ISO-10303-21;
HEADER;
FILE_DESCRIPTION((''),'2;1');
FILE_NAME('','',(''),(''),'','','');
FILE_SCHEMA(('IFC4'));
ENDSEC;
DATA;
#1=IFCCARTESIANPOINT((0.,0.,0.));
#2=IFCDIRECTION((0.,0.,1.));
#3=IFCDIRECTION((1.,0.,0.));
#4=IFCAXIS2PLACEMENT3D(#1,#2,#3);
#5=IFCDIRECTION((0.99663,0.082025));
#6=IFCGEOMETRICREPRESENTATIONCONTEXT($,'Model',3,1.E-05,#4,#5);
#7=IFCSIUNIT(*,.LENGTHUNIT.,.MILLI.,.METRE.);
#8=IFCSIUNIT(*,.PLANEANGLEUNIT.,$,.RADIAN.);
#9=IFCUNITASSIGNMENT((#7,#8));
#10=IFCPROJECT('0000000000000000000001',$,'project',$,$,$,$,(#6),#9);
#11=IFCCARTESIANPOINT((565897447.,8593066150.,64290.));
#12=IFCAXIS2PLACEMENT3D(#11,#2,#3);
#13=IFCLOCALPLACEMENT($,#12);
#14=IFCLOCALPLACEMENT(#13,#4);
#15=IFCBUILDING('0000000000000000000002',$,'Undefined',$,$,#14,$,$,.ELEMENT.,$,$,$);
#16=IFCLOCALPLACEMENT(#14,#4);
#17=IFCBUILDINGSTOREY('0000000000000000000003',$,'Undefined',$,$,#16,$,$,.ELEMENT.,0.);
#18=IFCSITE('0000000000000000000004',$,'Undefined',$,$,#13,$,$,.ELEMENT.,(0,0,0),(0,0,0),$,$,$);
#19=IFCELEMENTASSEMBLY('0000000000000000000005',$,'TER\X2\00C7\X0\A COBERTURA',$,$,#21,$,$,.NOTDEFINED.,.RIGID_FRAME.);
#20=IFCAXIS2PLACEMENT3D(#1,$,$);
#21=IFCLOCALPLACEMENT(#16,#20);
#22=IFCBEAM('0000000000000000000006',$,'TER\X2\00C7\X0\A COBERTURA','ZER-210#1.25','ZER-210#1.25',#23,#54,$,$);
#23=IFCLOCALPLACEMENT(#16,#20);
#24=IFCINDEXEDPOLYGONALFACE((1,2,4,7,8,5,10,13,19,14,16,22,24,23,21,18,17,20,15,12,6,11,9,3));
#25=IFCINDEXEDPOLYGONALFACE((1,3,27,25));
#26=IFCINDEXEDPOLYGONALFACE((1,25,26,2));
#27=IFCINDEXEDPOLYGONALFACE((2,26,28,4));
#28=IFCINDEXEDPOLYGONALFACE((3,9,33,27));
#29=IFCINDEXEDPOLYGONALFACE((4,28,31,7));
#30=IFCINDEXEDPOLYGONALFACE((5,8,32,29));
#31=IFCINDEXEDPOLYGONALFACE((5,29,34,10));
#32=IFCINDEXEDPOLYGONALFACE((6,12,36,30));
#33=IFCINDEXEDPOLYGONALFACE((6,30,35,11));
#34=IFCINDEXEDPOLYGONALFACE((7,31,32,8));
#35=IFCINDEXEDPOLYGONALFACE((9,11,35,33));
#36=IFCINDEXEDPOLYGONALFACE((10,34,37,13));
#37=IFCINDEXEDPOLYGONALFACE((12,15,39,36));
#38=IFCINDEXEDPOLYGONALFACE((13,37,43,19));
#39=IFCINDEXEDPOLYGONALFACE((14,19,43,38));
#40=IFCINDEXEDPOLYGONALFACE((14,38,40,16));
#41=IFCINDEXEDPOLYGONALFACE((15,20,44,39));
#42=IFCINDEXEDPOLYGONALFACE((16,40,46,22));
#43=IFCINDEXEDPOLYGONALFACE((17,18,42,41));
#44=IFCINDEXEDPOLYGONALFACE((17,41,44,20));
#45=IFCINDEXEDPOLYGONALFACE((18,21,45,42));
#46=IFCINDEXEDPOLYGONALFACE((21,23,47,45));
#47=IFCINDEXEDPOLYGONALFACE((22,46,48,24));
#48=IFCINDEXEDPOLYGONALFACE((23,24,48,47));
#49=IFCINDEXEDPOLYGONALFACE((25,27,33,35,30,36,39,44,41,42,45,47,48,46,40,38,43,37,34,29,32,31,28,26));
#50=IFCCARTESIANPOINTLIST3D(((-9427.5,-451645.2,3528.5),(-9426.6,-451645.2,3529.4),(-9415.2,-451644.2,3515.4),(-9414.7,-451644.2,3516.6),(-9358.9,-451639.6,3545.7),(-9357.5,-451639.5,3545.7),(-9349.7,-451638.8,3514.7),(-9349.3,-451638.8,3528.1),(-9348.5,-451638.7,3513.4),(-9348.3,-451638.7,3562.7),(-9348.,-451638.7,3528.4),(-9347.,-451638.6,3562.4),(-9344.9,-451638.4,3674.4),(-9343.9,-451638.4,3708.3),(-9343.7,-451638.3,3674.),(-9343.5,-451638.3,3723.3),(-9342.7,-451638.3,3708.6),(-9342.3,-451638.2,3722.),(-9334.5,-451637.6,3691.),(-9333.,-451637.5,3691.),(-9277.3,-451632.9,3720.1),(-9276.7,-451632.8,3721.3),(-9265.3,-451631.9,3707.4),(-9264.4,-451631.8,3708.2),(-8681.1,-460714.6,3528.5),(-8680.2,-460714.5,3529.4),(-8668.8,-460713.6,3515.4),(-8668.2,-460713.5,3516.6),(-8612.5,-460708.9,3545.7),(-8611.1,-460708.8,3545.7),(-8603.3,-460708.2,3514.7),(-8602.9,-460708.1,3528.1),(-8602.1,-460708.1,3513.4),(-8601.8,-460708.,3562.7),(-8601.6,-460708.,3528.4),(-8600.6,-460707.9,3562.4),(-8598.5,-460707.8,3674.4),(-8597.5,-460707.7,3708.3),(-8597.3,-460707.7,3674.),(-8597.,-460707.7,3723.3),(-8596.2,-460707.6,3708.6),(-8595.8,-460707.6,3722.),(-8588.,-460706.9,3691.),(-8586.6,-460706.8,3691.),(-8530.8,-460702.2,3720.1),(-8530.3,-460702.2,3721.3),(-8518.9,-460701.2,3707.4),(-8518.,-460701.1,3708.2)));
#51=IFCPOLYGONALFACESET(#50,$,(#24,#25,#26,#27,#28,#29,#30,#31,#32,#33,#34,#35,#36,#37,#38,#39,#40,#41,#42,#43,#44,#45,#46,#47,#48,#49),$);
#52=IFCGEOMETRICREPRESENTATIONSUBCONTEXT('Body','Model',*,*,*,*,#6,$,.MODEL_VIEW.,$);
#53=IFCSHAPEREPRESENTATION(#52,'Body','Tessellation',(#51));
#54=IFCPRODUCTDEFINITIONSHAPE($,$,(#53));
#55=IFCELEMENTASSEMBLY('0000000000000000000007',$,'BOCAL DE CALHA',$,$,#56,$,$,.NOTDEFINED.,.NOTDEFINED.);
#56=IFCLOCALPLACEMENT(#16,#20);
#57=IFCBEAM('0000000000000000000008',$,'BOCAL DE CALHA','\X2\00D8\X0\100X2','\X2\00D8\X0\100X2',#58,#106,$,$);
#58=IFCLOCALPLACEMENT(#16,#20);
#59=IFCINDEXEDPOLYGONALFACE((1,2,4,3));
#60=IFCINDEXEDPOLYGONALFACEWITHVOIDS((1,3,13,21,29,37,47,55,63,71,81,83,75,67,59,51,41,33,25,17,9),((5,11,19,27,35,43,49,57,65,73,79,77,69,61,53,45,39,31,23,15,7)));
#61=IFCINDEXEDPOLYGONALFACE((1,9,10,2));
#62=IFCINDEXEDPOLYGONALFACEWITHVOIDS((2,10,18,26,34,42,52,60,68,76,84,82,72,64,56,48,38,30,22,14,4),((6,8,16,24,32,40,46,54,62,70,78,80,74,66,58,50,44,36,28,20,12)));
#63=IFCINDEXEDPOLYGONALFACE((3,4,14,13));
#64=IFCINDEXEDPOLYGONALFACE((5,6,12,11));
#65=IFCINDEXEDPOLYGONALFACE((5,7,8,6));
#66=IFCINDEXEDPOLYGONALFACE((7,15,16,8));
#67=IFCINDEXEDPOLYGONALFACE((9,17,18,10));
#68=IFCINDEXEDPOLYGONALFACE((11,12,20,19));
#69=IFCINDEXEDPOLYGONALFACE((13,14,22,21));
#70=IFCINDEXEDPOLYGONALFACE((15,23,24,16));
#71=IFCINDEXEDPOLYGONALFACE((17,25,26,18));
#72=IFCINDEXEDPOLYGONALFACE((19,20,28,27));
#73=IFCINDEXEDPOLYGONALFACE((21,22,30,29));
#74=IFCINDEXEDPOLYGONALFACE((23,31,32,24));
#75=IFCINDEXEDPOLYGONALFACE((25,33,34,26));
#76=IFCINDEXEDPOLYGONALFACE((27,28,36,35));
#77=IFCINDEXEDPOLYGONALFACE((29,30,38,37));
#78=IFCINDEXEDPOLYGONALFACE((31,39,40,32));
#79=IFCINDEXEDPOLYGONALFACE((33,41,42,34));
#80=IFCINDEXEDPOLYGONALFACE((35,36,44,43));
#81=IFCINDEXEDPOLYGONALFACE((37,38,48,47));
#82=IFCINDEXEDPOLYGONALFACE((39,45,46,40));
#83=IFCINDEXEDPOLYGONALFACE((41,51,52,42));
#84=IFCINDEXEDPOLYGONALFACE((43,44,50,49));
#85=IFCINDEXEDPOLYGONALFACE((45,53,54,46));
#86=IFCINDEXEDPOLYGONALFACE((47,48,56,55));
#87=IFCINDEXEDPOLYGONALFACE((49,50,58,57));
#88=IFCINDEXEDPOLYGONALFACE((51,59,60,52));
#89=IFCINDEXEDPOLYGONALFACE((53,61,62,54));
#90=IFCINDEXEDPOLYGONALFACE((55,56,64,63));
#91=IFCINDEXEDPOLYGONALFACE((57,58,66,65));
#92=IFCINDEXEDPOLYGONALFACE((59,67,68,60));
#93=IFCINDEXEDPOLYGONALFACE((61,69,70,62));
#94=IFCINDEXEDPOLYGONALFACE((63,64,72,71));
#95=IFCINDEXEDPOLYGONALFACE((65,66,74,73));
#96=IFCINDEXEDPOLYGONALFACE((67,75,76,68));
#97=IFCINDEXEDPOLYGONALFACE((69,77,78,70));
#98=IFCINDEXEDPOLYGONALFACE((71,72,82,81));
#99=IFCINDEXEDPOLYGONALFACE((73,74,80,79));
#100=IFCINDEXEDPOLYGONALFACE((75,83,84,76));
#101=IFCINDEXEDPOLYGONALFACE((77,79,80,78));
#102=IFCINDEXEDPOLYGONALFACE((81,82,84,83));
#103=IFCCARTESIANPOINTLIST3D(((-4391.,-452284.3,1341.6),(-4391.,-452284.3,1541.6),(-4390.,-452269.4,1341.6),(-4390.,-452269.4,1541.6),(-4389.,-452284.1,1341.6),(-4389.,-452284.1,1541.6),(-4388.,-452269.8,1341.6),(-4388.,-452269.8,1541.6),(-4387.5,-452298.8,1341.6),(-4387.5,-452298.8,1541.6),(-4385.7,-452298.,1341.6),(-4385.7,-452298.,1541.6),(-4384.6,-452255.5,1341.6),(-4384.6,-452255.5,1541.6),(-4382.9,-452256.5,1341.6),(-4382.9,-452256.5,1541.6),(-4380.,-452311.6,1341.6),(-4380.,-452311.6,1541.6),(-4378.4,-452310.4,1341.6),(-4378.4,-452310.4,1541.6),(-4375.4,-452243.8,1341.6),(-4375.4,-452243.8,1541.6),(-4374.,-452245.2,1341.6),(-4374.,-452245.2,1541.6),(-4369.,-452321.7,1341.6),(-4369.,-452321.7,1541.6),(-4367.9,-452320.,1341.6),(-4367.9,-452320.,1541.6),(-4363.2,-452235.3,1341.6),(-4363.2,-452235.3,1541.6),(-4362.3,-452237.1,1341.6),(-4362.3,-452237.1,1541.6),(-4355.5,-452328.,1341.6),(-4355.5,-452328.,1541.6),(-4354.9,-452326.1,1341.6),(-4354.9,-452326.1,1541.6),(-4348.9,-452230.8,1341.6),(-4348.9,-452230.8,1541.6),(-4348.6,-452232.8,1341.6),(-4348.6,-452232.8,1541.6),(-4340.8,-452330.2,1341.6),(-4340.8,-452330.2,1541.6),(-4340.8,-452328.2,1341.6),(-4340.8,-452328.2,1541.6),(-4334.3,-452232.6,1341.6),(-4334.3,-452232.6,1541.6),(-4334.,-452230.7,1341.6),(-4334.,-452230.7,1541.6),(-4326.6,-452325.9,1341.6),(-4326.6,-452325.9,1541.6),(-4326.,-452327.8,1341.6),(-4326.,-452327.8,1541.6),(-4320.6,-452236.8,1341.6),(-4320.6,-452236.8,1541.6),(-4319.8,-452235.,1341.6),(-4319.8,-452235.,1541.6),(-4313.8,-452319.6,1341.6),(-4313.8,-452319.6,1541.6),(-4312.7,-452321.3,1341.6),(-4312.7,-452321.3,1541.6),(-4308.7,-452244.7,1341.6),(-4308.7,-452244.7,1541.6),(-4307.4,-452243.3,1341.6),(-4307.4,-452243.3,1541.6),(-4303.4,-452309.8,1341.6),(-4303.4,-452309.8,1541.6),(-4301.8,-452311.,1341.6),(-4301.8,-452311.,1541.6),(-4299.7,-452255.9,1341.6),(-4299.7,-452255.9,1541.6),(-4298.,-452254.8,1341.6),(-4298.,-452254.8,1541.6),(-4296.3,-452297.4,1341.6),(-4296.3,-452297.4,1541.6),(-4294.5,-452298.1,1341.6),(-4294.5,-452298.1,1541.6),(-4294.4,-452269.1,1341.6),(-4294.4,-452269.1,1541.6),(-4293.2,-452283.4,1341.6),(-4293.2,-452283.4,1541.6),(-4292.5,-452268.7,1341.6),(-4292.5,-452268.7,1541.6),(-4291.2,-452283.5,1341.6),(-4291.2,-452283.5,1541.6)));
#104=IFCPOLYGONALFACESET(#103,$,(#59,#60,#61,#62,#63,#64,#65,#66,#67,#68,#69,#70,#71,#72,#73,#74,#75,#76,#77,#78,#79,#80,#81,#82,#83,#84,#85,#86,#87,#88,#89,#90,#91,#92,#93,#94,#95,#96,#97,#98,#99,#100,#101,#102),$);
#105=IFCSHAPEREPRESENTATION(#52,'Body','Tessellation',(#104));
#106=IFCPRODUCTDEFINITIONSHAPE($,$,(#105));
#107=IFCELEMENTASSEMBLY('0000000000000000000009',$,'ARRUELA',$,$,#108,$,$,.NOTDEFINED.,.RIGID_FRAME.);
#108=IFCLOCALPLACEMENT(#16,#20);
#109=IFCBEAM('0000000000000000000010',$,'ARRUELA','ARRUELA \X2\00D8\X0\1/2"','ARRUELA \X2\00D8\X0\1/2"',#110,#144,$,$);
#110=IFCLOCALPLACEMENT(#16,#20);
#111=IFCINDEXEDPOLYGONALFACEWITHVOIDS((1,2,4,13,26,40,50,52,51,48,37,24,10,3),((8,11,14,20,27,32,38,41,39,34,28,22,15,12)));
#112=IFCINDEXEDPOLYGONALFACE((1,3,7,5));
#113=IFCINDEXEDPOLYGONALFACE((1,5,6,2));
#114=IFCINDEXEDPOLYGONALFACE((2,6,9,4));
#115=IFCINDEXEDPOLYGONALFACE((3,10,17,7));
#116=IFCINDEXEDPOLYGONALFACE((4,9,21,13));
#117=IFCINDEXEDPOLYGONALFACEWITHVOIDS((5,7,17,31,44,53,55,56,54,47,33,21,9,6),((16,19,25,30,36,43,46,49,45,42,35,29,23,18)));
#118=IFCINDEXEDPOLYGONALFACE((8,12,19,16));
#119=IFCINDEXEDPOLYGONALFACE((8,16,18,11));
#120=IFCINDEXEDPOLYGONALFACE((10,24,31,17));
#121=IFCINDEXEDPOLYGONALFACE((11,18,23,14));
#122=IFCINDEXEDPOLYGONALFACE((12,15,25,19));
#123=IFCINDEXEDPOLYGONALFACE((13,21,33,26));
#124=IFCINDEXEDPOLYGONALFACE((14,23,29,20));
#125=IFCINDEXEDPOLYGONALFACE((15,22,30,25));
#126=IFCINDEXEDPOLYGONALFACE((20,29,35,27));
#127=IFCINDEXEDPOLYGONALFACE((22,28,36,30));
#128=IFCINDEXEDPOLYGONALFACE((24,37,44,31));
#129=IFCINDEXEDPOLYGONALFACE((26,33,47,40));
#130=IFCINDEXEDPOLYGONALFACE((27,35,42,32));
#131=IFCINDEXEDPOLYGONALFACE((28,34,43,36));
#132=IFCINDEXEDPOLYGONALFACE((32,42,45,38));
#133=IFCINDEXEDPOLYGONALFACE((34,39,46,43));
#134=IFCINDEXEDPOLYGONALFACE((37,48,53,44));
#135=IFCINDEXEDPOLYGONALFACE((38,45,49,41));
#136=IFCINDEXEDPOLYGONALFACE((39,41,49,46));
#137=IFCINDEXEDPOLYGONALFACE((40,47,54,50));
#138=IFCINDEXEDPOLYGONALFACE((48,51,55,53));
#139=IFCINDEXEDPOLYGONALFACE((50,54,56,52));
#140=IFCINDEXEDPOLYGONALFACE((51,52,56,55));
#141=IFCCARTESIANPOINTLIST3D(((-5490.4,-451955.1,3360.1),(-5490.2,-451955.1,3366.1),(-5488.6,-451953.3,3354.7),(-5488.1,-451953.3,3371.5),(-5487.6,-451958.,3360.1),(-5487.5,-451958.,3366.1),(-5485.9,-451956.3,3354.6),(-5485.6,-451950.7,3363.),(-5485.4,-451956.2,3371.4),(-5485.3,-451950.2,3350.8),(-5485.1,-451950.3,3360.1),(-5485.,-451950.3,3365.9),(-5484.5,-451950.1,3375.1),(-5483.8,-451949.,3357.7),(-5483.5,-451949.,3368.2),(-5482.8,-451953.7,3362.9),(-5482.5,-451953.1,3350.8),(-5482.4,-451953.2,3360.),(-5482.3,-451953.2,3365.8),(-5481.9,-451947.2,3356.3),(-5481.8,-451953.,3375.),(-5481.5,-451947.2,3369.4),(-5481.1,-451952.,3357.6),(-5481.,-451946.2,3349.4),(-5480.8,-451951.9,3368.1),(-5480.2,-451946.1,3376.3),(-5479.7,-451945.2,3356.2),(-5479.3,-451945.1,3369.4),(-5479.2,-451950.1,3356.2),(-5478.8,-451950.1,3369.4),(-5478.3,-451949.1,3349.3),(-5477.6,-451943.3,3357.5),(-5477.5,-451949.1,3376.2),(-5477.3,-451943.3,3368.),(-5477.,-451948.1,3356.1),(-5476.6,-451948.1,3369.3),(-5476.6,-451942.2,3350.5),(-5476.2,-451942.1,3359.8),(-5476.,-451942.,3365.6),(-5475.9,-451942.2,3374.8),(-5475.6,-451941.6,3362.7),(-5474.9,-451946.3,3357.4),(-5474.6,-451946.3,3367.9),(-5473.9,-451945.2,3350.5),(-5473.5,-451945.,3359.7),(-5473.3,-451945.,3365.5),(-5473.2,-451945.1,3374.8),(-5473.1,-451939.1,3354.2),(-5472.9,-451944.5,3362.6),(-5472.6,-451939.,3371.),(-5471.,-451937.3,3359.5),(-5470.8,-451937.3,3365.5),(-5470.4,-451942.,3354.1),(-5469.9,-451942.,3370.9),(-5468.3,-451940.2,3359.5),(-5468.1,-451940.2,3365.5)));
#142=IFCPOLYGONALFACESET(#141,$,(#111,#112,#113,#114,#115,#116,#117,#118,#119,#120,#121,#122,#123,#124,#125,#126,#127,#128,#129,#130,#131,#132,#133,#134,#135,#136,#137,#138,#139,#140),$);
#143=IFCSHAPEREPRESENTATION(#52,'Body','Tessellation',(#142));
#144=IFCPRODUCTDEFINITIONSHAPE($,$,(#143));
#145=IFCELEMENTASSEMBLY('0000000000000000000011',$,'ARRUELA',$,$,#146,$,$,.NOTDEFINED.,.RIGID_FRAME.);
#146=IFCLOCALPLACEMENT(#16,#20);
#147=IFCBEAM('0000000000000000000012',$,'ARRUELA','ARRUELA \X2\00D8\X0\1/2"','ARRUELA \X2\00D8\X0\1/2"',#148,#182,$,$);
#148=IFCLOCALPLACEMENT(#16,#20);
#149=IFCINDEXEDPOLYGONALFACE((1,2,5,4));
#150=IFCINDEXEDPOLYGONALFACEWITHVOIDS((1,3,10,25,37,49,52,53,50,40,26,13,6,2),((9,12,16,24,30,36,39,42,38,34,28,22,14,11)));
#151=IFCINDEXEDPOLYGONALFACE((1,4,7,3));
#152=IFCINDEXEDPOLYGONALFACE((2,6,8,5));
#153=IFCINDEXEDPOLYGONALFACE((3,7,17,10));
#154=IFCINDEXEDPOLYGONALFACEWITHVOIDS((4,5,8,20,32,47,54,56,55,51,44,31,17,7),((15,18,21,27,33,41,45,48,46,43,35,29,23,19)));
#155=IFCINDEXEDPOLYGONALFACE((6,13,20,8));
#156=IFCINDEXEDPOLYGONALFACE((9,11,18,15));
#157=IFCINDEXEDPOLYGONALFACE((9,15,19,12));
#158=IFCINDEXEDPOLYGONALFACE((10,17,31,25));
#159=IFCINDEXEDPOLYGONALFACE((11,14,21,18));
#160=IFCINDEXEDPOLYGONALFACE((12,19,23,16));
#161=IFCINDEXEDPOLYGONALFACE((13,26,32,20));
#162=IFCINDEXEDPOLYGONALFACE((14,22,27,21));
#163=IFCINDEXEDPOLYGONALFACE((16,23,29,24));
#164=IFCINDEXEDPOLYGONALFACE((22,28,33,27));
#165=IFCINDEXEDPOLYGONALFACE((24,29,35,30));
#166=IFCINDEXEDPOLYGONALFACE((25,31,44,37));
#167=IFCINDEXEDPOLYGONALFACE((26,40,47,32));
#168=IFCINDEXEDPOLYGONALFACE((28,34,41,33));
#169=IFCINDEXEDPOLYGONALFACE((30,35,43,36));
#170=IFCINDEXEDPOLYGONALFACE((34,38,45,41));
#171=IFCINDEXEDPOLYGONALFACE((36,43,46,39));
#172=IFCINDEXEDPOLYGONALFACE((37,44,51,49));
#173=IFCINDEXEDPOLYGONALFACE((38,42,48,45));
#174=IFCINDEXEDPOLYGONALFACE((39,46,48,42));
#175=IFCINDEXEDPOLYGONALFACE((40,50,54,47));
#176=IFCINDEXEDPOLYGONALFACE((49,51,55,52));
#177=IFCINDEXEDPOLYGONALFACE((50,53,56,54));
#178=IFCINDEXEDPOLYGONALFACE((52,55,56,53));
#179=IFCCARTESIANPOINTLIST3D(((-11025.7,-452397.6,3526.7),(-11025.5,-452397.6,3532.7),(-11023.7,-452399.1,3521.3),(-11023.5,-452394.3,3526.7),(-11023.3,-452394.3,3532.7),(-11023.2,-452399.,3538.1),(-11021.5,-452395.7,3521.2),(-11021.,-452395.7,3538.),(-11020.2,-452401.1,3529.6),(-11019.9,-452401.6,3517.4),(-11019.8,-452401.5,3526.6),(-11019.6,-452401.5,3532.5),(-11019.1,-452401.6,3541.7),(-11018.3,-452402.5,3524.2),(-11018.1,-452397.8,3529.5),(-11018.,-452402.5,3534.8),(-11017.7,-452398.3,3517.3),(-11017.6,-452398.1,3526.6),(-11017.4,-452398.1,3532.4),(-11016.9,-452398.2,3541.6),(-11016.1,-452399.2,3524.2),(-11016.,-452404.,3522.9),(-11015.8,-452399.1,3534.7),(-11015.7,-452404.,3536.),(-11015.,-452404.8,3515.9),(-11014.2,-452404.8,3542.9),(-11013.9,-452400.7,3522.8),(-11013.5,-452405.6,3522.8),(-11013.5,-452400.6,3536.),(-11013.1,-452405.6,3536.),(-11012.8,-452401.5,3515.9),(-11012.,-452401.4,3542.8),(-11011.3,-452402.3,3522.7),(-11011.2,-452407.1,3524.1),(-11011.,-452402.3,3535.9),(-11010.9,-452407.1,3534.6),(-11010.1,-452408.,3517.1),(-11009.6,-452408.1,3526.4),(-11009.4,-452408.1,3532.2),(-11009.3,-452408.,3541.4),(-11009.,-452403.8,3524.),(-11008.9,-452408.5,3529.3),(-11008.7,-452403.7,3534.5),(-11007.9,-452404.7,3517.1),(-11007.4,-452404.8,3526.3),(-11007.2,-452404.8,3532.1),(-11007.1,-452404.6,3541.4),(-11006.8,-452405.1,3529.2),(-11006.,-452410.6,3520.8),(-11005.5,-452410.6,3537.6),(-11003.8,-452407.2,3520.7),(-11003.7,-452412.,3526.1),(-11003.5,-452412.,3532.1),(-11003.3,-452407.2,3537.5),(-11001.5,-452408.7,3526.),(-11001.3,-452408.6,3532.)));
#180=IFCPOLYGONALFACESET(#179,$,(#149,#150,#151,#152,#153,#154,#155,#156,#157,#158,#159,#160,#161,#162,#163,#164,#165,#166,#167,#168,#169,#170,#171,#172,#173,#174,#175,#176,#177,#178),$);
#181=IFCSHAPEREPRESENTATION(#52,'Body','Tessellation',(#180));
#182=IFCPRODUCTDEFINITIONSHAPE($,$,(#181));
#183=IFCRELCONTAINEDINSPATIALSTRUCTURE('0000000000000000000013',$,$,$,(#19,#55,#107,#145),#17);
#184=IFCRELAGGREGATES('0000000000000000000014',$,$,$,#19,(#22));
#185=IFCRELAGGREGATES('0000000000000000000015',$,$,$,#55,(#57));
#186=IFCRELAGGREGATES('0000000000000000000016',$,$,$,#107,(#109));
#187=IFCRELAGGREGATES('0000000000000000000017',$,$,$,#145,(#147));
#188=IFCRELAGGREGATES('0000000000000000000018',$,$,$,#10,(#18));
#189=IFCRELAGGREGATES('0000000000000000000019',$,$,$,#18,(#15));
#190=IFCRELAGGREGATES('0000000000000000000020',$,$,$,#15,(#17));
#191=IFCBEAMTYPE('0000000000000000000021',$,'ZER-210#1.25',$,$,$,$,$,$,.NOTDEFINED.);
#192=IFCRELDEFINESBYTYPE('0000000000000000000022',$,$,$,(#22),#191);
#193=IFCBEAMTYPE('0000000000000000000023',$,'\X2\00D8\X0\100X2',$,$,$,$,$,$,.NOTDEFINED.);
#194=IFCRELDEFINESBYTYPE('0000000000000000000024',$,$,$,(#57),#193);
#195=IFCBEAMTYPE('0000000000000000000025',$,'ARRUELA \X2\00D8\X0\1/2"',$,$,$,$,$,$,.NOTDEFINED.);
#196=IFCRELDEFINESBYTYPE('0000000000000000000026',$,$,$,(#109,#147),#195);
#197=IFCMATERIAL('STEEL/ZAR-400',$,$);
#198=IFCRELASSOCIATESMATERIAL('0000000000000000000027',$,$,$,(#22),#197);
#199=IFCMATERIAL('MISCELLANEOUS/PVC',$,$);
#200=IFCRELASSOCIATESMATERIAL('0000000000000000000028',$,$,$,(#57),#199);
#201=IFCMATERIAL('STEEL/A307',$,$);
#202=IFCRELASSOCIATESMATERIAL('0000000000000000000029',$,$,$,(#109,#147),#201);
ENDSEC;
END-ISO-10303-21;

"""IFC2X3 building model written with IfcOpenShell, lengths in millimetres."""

from ifc_helpers import new_model, si_unit, direction, frame, origin_with_axes, origin_2d_with_axis, place, context, subcontext, project, spatial, polyline, hollow_circle, outline, extrude, material, type_object, element, aggregate, save


model = new_model("IFC2X3")

# Units and contexts
model_context = context("Model", 3, precision=1e-05, world=origin_with_axes(), true_north=direction((0.99663, 0.082025)))
body_context = subcontext(model_context, "Body", "Model", "MODEL_VIEW")
ifc_project = project(units=[si_unit("LENGTHUNIT", "METRE", prefix="MILLI"), si_unit("PLANEANGLEUNIT", "RADIAN")], contexts=[model_context])

# Site, building, storey
site_placement = place(None, frame((565897447.0, 8593066150.0, 64290.0), z_axis=(0.0, 0.0, 1.0), x_axis=(1.0, 0.0, 0.0)))
site = spatial("IfcSite", under=ifc_project, at=site_placement, Name="Undefined", CompositionType="ELEMENT", RefLatitude=(0, 0, 0), RefLongitude=(0, 0, 0))
building_placement = place(site_placement, origin_with_axes())
building = spatial("IfcBuilding", under=site, at=building_placement, Name="Undefined", CompositionType="ELEMENT")
storey_placement = place(building_placement, origin_with_axes())
storey = spatial("IfcBuildingStorey", under=building, at=storey_placement, Name="Undefined", CompositionType="ELEMENT", Elevation=0.0)

# Element assemblies, beams
ifc_material_1 = material(Name="STEEL/ZAR-400")
beam_type_1 = type_object("IfcBeamType", Name="ZER-210#1.25", PredefinedType="NOTDEFINED")
assembly_1_placement = place(storey_placement, origin_with_axes())
assembly_1 = element("IfcElementAssembly", 1, at=assembly_1_placement, inside=storey, Name="TERÇA COBERTURA", AssemblyPlace="NOTDEFINED", PredefinedType="RIGID_FRAME")
beam_1_placement = place(assembly_1_placement, frame((-9346.0, -451638.5, 3618.4), z_axis=(0.029885, 0.00246, 0.99955), x_axis=(0.082025, -0.99663, 0.0)))
beam_1 = element("IfcBeam", 2, at=beam_1_placement, type_object=beam_type_1, material=ifc_material_1, Name="TERÇA COBERTURA", Description="ZER-210#1.25", ObjectType="ZER-210#1.25", context=body_context, shape_type="SweptSolid", body=[
    extrude(outline(polyline([(-65.9, 103.7), (-78.2, 91.4), (-79.1, 92.3), (-66.4, 105.0), (0.6, 105.0), (0.6, 90.0), (-9.4, 73.0), (0.6, 56.0), (0.6, -55.7), (10.8, -73.0), (0.6, -90.3), (0.6, -103.8), (65.9, -103.7), (78.2, -91.4), (79.1, -92.3), (66.4, -105.0), (-0.6, -105.0), (-0.6, -90.0), (9.4, -73.0), (-0.6, -56.0), (-0.6, 55.7), (-10.8, 73.0), (-0.6, 90.3), (-0.6, 103.8), (-65.9, 103.7)])), frame((9100.0, 0.0, 0.0), z_axis=(-1.0, 0.0, 0.0), x_axis=(0.0, -1.0, 0.0)), (0.0, 0.0, 1.0), 9100.0),
])
aggregate(assembly_1, [beam_1])
assembly_2_placement = place(storey_placement, origin_with_axes())
assembly_2 = element("IfcElementAssembly", 3, at=assembly_2_placement, inside=storey, Name="BOCAL DE CALHA", AssemblyPlace="NOTDEFINED", PredefinedType="NOTDEFINED")
ifc_material_2 = material(Name="MISCELLANEOUS/PVC")
beam_type_2 = type_object("IfcBeamType", Name="Ø100X2", PredefinedType="NOTDEFINED")
beam_2_placement = place(assembly_2_placement, frame((-4341.1, -452280.2, 1541.6), z_axis=(0.082025, -0.99663, 0.0), x_axis=(0.0, 0.0, -1.0)))
beam_2 = element("IfcBeam", 4, at=beam_2_placement, type_object=beam_type_2, material=ifc_material_2, Name="BOCAL DE CALHA", Description="Ø100X2", ObjectType="Ø100X2", context=body_context, shape_type="SweptSolid", body=[
    extrude(hollow_circle(Radius=50.0, WallThickness=2.0, at=origin_2d_with_axis()), frame((200.0, 0.0, 0.0), z_axis=(-1.0, 0.0, 0.0), x_axis=(0.0, -1.0, 0.0)), (0.0, 0.0, 1.0), 200.0),
])
aggregate(assembly_2, [beam_2])
assembly_3_placement = place(storey_placement, origin_with_axes())
assembly_3 = element("IfcElementAssembly", 5, at=assembly_3_placement, inside=storey, Name="ARRUELA", AssemblyPlace="NOTDEFINED", PredefinedType="RIGID_FRAME")
ifc_material_3 = material(Name="STEEL/A307")
beam_type_3 = type_object("IfcBeamType", Name="ARRUELA Ø1/2\"", PredefinedType="NOTDEFINED")
beam_3_placement = place(assembly_3_placement, frame((-5477.9, -451949.1, 3362.8), z_axis=(-0.736334, -0.676203, 0.02368), x_axis=(-0.675958, 0.736711, 0.018398)))
beam_3 = element("IfcBeam", 6, at=beam_3_placement, type_object=beam_type_3, material=ifc_material_3, Name="ARRUELA", Description="ARRUELA Ø1/2\"", ObjectType="ARRUELA Ø1/2\"", context=body_context, shape_type="SweptSolid", body=[
    extrude(outline(polyline([(-12.2, 5.9), (-8.4, 10.5), (-3.0, 13.2), (3.0, 13.2), (8.4, 10.5), (12.2, 5.9), (13.5, 0.0), (12.2, -5.9), (8.4, -10.5), (3.0, -13.2), (-3.0, -13.2), (-8.4, -10.5), (-12.2, -5.9), (-13.5, 0.0), (-12.2, 5.9)]), holes=[polyline([(5.3, 4.2), (2.9, 6.1), (0.0, 6.8), (-2.9, 6.1), (-5.3, 4.2), (-6.6, 1.5), (-6.6, -1.5), (-5.3, -4.2), (-2.9, -6.1), (0.0, -6.7), (2.9, -6.1), (5.3, -4.2), (6.6, -1.5), (6.6, 1.5), (5.3, 4.2)])]), frame((4.0, 0.0, 0.0), z_axis=(-1.0, 0.0, 0.0), x_axis=(0.0, -1.0, 0.0)), (0.0, 0.0, 1.0), 4.0),
])
aggregate(assembly_3, [beam_3])
assembly_4_placement = place(storey_placement, origin_with_axes())
assembly_4 = element("IfcElementAssembly", 7, at=assembly_4_placement, inside=storey, Name="ARRUELA", AssemblyPlace="NOTDEFINED", PredefinedType="RIGID_FRAME")
beam_4_placement = place(assembly_4_placement, frame((-11014.6, -452404.8, 3529.4), z_axis=(-0.836984, 0.546715, 0.02368), x_axis=(0.546411, 0.837315, -0.018398)))
beam_4 = element("IfcBeam", 8, at=beam_4_placement, type_object=beam_type_3, material=ifc_material_3, Name="ARRUELA", Description="ARRUELA Ø1/2\"", ObjectType="ARRUELA Ø1/2\"", context=body_context, shape_type="SweptSolid", body=[
    extrude(outline(polyline([(-12.2, 5.9), (-8.4, 10.5), (-3.0, 13.2), (3.0, 13.2), (8.4, 10.5), (12.2, 5.9), (13.5, 0.0), (12.2, -5.9), (8.4, -10.5), (3.0, -13.2), (-3.0, -13.2), (-8.4, -10.5), (-12.2, -5.9), (-13.5, 0.0), (-12.2, 5.9)]), holes=[polyline([(5.3, 4.2), (2.9, 6.1), (0.0, 6.8), (-2.9, 6.1), (-5.3, 4.2), (-6.6, 1.5), (-6.6, -1.5), (-5.3, -4.2), (-2.9, -6.1), (0.0, -6.7), (2.9, -6.1), (5.3, -4.2), (6.6, -1.5), (6.6, 1.5), (5.3, 4.2)])]), frame((4.0, 0.0, 0.0), z_axis=(-1.0, 0.0, 0.0), x_axis=(0.0, -1.0, 0.0)), (0.0, 0.0, 1.0), 4.0),
])
aggregate(assembly_4, [beam_4])

save(model, "model.ifc")
